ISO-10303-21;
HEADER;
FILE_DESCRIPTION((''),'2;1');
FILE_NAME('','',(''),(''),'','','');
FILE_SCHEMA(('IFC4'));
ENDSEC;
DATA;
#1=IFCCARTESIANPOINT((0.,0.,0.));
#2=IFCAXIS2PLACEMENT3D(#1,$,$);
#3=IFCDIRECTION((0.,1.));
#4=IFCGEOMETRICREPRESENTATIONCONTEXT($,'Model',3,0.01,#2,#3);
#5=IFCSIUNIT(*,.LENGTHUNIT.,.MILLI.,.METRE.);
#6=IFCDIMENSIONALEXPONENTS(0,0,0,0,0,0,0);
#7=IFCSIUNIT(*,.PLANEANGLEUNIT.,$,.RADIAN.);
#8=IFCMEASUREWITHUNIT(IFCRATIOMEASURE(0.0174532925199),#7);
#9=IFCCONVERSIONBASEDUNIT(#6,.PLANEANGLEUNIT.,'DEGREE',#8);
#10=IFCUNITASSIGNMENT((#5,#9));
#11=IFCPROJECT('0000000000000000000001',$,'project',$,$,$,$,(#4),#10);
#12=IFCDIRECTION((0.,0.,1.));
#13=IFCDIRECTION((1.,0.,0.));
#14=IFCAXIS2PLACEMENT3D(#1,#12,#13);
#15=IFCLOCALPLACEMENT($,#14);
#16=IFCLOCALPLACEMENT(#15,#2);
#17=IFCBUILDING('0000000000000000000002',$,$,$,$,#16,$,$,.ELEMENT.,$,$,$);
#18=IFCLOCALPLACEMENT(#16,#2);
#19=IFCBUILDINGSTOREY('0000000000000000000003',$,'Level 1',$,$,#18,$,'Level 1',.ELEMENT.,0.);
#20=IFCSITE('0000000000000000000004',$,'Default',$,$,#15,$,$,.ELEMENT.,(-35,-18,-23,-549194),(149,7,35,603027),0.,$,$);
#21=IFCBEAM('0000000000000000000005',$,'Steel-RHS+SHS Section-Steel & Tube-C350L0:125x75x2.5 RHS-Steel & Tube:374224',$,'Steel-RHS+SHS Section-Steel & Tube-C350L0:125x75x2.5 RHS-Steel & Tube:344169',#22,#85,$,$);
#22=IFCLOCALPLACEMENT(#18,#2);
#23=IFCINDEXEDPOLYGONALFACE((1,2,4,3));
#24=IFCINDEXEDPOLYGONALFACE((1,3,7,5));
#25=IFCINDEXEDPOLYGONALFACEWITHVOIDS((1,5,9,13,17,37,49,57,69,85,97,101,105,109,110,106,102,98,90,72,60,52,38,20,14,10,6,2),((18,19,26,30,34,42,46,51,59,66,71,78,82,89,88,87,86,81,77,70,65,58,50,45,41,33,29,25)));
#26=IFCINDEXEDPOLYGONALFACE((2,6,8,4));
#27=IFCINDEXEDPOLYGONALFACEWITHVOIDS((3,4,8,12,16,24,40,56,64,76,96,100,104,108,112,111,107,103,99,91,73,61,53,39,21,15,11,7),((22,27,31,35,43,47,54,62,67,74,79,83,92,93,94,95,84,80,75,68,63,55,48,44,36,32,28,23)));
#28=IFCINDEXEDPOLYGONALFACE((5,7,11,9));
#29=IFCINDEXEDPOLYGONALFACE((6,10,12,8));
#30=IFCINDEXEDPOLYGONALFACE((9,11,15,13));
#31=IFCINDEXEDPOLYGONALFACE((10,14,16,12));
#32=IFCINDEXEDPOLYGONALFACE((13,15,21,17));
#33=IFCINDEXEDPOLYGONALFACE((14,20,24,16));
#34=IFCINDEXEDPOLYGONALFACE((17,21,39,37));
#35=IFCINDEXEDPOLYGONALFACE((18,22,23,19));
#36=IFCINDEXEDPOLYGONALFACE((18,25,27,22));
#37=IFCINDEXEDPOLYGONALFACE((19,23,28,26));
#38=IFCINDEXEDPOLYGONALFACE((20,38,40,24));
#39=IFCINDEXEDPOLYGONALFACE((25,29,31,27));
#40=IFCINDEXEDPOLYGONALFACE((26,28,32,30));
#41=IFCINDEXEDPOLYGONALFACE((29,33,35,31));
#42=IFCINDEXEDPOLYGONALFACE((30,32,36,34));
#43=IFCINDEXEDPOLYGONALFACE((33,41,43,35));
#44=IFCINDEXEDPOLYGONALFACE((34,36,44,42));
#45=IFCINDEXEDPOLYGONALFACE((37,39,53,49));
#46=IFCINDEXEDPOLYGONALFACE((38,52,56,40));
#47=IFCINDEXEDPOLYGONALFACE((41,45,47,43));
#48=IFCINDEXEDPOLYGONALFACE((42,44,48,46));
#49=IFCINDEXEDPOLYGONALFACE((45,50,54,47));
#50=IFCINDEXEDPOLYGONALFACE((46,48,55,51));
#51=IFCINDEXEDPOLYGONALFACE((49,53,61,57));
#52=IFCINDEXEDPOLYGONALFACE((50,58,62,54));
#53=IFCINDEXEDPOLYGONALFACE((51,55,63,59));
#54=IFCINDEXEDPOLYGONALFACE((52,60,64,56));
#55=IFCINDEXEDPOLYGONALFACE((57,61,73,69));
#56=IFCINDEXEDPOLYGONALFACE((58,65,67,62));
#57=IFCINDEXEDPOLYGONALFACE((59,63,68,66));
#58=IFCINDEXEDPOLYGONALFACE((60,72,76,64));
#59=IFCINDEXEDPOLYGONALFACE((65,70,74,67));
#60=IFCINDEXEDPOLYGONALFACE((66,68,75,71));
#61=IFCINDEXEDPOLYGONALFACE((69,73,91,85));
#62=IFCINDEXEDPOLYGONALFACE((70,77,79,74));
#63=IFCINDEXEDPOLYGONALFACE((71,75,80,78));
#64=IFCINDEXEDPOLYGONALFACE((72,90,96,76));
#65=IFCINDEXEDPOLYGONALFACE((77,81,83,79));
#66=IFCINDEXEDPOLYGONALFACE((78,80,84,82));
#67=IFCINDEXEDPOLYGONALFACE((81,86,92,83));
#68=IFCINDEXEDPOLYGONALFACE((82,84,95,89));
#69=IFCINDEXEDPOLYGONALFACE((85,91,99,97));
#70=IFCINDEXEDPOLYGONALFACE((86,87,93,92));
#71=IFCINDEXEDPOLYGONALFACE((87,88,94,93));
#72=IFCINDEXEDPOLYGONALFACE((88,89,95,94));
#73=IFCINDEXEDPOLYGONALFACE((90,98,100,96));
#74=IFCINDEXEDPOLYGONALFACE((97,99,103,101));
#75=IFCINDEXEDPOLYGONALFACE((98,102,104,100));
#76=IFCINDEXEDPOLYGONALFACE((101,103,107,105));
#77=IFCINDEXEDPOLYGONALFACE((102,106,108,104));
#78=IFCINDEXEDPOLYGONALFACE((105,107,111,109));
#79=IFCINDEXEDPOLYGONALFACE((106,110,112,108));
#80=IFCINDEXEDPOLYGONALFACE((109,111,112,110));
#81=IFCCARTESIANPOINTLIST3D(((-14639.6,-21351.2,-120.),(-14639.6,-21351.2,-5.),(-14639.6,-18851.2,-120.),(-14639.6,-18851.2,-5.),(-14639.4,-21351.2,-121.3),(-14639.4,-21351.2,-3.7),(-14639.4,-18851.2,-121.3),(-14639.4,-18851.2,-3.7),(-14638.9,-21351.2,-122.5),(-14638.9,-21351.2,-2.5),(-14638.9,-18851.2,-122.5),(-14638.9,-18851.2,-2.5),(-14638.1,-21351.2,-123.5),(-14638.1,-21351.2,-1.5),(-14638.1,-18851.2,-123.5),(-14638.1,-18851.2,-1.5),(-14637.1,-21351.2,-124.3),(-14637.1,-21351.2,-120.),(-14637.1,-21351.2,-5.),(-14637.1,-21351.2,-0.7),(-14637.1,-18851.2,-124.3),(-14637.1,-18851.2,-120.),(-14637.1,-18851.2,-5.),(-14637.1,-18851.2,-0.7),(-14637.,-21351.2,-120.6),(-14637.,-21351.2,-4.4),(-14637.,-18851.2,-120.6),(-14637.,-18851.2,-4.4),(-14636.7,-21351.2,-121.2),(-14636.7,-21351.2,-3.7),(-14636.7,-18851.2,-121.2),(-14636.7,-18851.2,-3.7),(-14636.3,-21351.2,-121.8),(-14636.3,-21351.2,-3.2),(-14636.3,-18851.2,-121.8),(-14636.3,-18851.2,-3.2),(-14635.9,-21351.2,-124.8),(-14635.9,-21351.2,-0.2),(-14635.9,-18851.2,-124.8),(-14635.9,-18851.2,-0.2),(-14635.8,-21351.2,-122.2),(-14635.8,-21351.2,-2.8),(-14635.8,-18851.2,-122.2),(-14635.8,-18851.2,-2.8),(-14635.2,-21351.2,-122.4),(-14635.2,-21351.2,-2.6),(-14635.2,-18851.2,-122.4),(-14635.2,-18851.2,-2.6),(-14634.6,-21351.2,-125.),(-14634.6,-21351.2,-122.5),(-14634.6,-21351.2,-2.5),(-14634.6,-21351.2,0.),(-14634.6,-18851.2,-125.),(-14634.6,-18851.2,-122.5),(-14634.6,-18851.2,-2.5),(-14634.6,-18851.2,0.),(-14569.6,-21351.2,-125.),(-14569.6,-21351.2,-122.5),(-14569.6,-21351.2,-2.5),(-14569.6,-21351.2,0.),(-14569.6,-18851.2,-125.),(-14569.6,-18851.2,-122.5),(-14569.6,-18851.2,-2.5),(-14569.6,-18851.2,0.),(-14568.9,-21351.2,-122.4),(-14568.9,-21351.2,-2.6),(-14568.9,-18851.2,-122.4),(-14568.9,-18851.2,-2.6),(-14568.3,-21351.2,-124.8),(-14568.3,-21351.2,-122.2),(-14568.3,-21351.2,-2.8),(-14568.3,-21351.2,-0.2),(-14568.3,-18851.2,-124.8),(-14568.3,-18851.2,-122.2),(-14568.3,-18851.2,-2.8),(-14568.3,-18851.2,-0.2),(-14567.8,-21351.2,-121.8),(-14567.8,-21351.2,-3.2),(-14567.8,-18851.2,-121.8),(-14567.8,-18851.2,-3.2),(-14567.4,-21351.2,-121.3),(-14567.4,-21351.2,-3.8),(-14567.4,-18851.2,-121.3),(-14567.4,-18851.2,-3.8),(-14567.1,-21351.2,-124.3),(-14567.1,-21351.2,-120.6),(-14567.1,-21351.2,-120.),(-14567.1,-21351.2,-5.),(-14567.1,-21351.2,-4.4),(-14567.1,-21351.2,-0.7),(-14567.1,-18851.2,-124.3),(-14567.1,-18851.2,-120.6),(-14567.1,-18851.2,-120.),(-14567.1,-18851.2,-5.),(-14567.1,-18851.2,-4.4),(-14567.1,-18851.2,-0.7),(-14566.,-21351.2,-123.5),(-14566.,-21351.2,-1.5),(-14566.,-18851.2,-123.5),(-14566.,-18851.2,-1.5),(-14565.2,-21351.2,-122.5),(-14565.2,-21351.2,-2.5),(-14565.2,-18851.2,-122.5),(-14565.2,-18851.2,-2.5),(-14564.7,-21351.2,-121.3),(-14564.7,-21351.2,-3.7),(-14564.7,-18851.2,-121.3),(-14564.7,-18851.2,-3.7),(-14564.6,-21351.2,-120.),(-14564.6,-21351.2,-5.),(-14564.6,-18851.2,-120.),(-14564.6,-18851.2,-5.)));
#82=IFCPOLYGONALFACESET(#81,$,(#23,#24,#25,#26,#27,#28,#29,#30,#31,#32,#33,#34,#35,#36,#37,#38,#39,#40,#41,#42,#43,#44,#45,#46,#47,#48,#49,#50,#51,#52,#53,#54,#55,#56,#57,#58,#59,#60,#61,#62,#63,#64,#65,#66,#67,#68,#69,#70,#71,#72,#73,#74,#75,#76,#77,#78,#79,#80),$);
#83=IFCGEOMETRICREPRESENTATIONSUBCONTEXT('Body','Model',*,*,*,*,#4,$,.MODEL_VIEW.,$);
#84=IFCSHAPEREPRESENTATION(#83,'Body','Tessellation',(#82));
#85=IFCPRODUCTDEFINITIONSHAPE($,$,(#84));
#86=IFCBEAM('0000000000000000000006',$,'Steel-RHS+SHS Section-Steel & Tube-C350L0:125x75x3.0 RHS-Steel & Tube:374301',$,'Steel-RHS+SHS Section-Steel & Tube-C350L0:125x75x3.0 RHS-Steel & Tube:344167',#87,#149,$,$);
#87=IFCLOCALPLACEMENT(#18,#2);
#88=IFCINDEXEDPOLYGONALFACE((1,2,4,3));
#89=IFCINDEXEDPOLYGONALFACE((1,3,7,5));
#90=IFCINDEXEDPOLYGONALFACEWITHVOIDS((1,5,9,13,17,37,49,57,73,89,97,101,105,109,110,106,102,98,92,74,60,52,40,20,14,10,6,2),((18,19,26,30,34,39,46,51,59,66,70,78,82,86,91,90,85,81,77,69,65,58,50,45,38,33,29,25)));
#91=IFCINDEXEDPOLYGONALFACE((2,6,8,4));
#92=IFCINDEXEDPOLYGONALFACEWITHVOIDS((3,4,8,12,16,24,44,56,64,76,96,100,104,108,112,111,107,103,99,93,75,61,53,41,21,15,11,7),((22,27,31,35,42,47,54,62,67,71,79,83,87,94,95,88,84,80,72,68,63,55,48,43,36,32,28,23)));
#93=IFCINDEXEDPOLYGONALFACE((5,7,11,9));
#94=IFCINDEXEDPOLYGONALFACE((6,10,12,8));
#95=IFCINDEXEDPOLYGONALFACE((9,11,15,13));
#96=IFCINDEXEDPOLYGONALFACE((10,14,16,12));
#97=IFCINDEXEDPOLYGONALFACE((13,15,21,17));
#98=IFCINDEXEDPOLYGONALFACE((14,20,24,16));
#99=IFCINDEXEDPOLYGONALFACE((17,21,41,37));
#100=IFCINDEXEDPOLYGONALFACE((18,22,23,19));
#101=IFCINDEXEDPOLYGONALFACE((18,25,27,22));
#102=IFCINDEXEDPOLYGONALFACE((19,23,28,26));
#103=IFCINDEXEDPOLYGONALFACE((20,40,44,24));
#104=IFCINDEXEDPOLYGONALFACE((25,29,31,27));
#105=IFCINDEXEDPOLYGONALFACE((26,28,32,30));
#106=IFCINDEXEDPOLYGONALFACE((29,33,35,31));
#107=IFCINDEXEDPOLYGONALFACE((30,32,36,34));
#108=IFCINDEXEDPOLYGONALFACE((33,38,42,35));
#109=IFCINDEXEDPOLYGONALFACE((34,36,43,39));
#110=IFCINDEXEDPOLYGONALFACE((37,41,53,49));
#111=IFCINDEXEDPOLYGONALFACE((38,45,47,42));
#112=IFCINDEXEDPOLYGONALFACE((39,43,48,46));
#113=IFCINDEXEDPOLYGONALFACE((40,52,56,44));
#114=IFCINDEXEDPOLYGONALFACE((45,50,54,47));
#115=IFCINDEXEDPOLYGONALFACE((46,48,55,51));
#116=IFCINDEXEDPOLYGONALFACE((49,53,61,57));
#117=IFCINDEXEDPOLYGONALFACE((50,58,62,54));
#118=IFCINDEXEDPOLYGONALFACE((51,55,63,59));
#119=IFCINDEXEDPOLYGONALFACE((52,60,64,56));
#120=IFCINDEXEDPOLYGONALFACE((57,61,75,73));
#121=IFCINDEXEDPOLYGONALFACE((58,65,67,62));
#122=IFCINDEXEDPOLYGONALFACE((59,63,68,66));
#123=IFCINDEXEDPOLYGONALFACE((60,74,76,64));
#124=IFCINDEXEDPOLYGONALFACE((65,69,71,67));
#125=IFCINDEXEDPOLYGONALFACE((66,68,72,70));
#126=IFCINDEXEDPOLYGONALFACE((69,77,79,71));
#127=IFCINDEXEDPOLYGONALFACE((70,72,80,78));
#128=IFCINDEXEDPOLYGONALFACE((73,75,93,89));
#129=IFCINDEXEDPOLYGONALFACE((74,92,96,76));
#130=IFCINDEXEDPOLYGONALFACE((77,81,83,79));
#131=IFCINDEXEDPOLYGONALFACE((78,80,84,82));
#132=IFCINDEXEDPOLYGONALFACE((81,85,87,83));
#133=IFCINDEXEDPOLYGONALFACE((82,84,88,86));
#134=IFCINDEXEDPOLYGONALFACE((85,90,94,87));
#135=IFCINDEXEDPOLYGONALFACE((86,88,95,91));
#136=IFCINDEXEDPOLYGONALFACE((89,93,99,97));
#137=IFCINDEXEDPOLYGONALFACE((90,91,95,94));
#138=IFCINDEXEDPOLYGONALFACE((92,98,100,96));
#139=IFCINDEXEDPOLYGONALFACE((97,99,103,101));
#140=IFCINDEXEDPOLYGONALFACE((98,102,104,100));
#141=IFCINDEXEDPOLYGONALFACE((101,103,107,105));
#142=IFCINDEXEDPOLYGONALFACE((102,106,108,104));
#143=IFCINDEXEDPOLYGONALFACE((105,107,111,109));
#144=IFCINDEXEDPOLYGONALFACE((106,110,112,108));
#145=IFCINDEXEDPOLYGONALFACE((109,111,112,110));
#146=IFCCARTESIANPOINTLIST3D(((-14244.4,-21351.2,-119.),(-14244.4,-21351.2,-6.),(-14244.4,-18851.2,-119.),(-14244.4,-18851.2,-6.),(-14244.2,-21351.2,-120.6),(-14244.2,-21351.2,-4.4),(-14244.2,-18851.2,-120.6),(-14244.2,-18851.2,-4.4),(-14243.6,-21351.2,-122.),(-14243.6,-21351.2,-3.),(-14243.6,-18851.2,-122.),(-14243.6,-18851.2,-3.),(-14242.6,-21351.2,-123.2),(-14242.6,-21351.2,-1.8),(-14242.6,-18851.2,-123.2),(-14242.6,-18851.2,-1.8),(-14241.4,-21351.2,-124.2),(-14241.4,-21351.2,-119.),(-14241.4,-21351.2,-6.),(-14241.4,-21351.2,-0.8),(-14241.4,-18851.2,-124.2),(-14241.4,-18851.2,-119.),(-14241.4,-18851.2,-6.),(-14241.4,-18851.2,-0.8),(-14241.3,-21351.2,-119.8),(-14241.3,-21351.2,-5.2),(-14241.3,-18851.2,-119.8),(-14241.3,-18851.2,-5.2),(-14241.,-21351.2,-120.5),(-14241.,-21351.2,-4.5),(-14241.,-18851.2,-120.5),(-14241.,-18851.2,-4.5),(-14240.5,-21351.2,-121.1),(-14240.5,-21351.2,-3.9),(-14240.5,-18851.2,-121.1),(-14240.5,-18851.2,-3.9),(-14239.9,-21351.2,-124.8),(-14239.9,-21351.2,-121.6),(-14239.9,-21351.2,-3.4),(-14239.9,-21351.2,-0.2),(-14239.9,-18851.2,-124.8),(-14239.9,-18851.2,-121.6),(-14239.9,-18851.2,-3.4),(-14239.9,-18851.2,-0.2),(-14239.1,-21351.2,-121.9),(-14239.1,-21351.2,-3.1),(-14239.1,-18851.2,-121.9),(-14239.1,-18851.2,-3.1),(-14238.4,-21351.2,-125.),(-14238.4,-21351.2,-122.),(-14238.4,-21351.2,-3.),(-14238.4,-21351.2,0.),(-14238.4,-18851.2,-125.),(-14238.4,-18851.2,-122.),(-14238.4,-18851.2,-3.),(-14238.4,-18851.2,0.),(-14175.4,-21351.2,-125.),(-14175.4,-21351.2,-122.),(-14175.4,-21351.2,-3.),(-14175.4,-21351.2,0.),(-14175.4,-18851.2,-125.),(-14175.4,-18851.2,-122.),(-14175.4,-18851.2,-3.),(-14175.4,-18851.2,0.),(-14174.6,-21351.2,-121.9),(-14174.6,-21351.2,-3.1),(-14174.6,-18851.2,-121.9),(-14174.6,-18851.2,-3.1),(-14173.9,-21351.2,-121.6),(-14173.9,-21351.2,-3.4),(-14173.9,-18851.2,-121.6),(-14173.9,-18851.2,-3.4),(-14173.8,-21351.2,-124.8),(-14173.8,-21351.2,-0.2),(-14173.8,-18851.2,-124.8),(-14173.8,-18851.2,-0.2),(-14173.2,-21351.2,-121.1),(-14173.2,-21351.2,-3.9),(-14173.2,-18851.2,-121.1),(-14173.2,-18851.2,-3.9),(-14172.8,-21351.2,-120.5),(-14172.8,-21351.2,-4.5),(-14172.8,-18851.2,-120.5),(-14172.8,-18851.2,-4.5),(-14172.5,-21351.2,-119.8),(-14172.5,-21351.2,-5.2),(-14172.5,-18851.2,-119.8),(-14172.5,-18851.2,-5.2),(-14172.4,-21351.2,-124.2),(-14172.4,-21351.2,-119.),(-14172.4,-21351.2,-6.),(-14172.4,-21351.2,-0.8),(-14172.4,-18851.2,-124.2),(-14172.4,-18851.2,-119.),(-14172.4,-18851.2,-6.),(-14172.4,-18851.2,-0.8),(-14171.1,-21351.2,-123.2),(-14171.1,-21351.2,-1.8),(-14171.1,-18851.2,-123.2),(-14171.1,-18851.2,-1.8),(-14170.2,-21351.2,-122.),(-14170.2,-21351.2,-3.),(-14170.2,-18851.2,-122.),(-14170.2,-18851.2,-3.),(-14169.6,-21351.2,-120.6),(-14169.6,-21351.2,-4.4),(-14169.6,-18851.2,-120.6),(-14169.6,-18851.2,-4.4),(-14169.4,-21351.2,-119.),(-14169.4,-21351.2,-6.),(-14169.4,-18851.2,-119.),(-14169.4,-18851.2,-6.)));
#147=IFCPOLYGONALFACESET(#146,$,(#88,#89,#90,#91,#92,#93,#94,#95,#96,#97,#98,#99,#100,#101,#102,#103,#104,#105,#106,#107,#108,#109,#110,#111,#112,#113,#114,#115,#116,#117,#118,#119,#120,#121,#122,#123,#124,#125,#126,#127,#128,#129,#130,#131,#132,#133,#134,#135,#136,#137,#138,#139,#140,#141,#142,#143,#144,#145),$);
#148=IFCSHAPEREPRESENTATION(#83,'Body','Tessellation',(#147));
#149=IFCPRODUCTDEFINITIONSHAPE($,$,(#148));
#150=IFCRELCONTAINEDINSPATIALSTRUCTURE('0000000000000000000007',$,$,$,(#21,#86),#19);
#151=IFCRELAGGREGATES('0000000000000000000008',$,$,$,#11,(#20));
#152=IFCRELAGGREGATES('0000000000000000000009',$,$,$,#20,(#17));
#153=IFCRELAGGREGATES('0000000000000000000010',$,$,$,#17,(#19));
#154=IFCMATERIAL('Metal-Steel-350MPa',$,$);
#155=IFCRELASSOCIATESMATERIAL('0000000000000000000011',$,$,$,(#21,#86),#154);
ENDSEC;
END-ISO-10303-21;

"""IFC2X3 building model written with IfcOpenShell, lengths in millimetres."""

from ifc_helpers import new_model, entity, si_unit, converted_unit, direction, frame, frame_2d, origin, origin_with_axes, place, context, subcontext, project, spatial, polyline, circle_curve, parameter, trimmed, segment, composite_curve, outline, extrude, material, element, save


model = new_model("IFC2X3")

# Units and contexts
model_context = context("Model", 3, precision=0.01, world=origin(), true_north=direction((0.0, 1.0)))
body_context = subcontext(model_context, "Body", "Model", "MODEL_VIEW")
ifc_project = project(units=[si_unit("LENGTHUNIT", "METRE", prefix="MILLI"), converted_unit("PLANEANGLEUNIT", "DEGREE", entity("IfcRatioMeasure", 0.0174532925199), si_unit("PLANEANGLEUNIT", "RADIAN"), dimensions=[0, 0, 0, 0, 0, 0, 0])], contexts=[model_context])

# Site, building, storey
site_placement = place(None, origin_with_axes())
site = spatial("IfcSite", under=ifc_project, at=site_placement, Name="Default", CompositionType="ELEMENT", RefLatitude=(-35, -18, -23, -549194), RefLongitude=(149, 7, 35, 603027), RefElevation=0.0)
building_placement = place(site_placement, origin())
building = spatial("IfcBuilding", under=site, at=building_placement, CompositionType="ELEMENT")
storey_placement = place(building_placement, origin())
storey = spatial("IfcBuildingStorey", under=building, at=storey_placement, Name="Level 1", LongName="Level 1", CompositionType="ELEMENT", Elevation=0.0)

# Beams
ifc_material = material(Name="Metal-Steel-350MPa")
beam_1_placement = place(storey_placement, frame((-14602.1, -18851.2, 0.0), z_axis=(0.0, 0.0, 1.0), x_axis=(0.0, -1.0, 0.0)))
element("IfcBeam", 1, at=beam_1_placement, inside=storey, material=ifc_material, Name="Steel-RHS+SHS Section-Steel & Tube-C350L0:125x75x2.5 RHS-Steel & Tube:374224", ObjectType="Steel-RHS+SHS Section-Steel & Tube-C350L0:125x75x2.5 RHS-Steel & Tube:344169", context=body_context, shape_type="SweptSolid", body=[
    extrude(outline(composite_curve([segment(trimmed(circle_curve(frame_2d((-32.5, -57.5), x_axis=(1.0, 0.0)), 5.0), [parameter(180.0)], [parameter(270.0)], True, "PARAMETER"), True, "CONTINUOUS"), segment(polyline([(-32.5, -62.5), (32.5, -62.5)]), True, "CONTINUOUS"), segment(trimmed(circle_curve(frame_2d((32.5, -57.5), x_axis=(1.0, 0.0)), 5.0), [parameter(270.0)], [parameter(0.0)], True, "PARAMETER"), True, "CONTINUOUS"), segment(polyline([(37.5, -57.5), (37.5, 57.5)]), True, "CONTINUOUS"), segment(trimmed(circle_curve(frame_2d((32.5, 57.5), x_axis=(1.0, 0.0)), 5.0), [parameter(0.0)], [parameter(90.0)], True, "PARAMETER"), True, "CONTINUOUS"), segment(polyline([(32.5, 62.5), (-32.5, 62.5)]), True, "CONTINUOUS"), segment(trimmed(circle_curve(frame_2d((-32.5, 57.5), x_axis=(1.0, 0.0)), 5.0), [parameter(90.0)], [parameter(180.0)], True, "PARAMETER"), True, "CONTINUOUS"), segment(polyline([(-37.5, 57.5), (-37.5, -57.5)]), True, "CONTINUOUS")], self_intersect=False), holes=[composite_curve([segment(polyline([(32.5, -60.0), (-32.5, -60.0)]), True, "CONTINUOUS"), segment(trimmed(circle_curve(frame_2d((-32.5, -57.5), x_axis=(1.0, 0.0)), 2.5), [parameter(180.0)], [parameter(270.0)], True, "PARAMETER"), False, "CONTINUOUS"), segment(polyline([(-35.0, -57.5), (-35.0, 57.5)]), True, "CONTINUOUS"), segment(trimmed(circle_curve(frame_2d((-32.5, 57.5), x_axis=(1.0, 0.0)), 2.5), [parameter(90.0)], [parameter(180.0)], True, "PARAMETER"), False, "CONTINUOUS"), segment(polyline([(-32.5, 60.0), (32.5, 60.0)]), True, "CONTINUOUS"), segment(trimmed(circle_curve(frame_2d((32.5, 57.5), x_axis=(1.0, 0.0)), 2.5), [parameter(360.0)], [parameter(90.0)], True, "PARAMETER"), False, "CONTINUOUS"), segment(polyline([(35.0, 57.5), (35.0, -57.5)]), True, "CONTINUOUS"), segment(trimmed(circle_curve(frame_2d((32.5, -57.5), x_axis=(1.0, 0.0)), 2.5), [parameter(270.0)], [parameter(0.0)], True, "PARAMETER"), False, "CONTINUOUS")], self_intersect=False)]), frame((0.0, 0.0, -62.5), z_axis=(1.0, 0.0, 0.0), x_axis=(0.0, -1.0, 0.0)), (0.0, 0.0, 1.0), 2500.0),
])
beam_2_placement = place(storey_placement, frame((-14206.9, -18851.2, 0.0), z_axis=(0.0, 0.0, 1.0), x_axis=(0.0, -1.0, 0.0)))
element("IfcBeam", 2, at=beam_2_placement, inside=storey, material=ifc_material, Name="Steel-RHS+SHS Section-Steel & Tube-C350L0:125x75x3.0 RHS-Steel & Tube:374301", ObjectType="Steel-RHS+SHS Section-Steel & Tube-C350L0:125x75x3.0 RHS-Steel & Tube:344167", context=body_context, shape_type="SweptSolid", body=[
    extrude(outline(composite_curve([segment(trimmed(circle_curve(frame_2d((-31.5, -56.5), x_axis=(1.0, 0.0)), 6.0), [parameter(180.0)], [parameter(270.0)], True, "PARAMETER"), True, "CONTINUOUS"), segment(polyline([(-31.5, -62.5), (31.5, -62.5)]), True, "CONTINUOUS"), segment(trimmed(circle_curve(frame_2d((31.5, -56.5), x_axis=(1.0, 0.0)), 6.0), [parameter(270.0)], [parameter(0.0)], True, "PARAMETER"), True, "CONTINUOUS"), segment(polyline([(37.5, -56.5), (37.5, 56.5)]), True, "CONTINUOUS"), segment(trimmed(circle_curve(frame_2d((31.5, 56.5), x_axis=(1.0, 0.0)), 6.0), [parameter(0.0)], [parameter(90.0)], True, "PARAMETER"), True, "CONTINUOUS"), segment(polyline([(31.5, 62.5), (-31.5, 62.5)]), True, "CONTINUOUS"), segment(trimmed(circle_curve(frame_2d((-31.5, 56.5), x_axis=(1.0, 0.0)), 6.0), [parameter(90.0)], [parameter(180.0)], True, "PARAMETER"), True, "CONTINUOUS"), segment(polyline([(-37.5, 56.5), (-37.5, -56.5)]), True, "CONTINUOUS")], self_intersect=False), holes=[composite_curve([segment(polyline([(31.5, -59.5), (-31.5, -59.5)]), True, "CONTINUOUS"), segment(trimmed(circle_curve(frame_2d((-31.5, -56.5), x_axis=(1.0, 0.0)), 3.0), [parameter(180.0)], [parameter(270.0)], True, "PARAMETER"), False, "CONTINUOUS"), segment(polyline([(-34.5, -56.5), (-34.5, 56.5)]), True, "CONTINUOUS"), segment(trimmed(circle_curve(frame_2d((-31.5, 56.5), x_axis=(1.0, 0.0)), 3.0), [parameter(90.0)], [parameter(180.0)], True, "PARAMETER"), False, "CONTINUOUS"), segment(polyline([(-31.5, 59.5), (31.5, 59.5)]), True, "CONTINUOUS"), segment(trimmed(circle_curve(frame_2d((31.5, 56.5), x_axis=(1.0, 0.0)), 3.0), [parameter(360.0)], [parameter(90.0)], True, "PARAMETER"), False, "CONTINUOUS"), segment(polyline([(34.5, 56.5), (34.5, -56.5)]), True, "CONTINUOUS"), segment(trimmed(circle_curve(frame_2d((31.5, -56.5), x_axis=(1.0, 0.0)), 3.0), [parameter(270.0)], [parameter(360.0)], True, "PARAMETER"), False, "CONTINUOUS")], self_intersect=False)]), frame((0.0, 0.0, -62.5), z_axis=(1.0, 0.0, 0.0), x_axis=(0.0, -1.0, 0.0)), (0.0, 0.0, 1.0), 2500.0),
])

save(model, "model.ifc")
